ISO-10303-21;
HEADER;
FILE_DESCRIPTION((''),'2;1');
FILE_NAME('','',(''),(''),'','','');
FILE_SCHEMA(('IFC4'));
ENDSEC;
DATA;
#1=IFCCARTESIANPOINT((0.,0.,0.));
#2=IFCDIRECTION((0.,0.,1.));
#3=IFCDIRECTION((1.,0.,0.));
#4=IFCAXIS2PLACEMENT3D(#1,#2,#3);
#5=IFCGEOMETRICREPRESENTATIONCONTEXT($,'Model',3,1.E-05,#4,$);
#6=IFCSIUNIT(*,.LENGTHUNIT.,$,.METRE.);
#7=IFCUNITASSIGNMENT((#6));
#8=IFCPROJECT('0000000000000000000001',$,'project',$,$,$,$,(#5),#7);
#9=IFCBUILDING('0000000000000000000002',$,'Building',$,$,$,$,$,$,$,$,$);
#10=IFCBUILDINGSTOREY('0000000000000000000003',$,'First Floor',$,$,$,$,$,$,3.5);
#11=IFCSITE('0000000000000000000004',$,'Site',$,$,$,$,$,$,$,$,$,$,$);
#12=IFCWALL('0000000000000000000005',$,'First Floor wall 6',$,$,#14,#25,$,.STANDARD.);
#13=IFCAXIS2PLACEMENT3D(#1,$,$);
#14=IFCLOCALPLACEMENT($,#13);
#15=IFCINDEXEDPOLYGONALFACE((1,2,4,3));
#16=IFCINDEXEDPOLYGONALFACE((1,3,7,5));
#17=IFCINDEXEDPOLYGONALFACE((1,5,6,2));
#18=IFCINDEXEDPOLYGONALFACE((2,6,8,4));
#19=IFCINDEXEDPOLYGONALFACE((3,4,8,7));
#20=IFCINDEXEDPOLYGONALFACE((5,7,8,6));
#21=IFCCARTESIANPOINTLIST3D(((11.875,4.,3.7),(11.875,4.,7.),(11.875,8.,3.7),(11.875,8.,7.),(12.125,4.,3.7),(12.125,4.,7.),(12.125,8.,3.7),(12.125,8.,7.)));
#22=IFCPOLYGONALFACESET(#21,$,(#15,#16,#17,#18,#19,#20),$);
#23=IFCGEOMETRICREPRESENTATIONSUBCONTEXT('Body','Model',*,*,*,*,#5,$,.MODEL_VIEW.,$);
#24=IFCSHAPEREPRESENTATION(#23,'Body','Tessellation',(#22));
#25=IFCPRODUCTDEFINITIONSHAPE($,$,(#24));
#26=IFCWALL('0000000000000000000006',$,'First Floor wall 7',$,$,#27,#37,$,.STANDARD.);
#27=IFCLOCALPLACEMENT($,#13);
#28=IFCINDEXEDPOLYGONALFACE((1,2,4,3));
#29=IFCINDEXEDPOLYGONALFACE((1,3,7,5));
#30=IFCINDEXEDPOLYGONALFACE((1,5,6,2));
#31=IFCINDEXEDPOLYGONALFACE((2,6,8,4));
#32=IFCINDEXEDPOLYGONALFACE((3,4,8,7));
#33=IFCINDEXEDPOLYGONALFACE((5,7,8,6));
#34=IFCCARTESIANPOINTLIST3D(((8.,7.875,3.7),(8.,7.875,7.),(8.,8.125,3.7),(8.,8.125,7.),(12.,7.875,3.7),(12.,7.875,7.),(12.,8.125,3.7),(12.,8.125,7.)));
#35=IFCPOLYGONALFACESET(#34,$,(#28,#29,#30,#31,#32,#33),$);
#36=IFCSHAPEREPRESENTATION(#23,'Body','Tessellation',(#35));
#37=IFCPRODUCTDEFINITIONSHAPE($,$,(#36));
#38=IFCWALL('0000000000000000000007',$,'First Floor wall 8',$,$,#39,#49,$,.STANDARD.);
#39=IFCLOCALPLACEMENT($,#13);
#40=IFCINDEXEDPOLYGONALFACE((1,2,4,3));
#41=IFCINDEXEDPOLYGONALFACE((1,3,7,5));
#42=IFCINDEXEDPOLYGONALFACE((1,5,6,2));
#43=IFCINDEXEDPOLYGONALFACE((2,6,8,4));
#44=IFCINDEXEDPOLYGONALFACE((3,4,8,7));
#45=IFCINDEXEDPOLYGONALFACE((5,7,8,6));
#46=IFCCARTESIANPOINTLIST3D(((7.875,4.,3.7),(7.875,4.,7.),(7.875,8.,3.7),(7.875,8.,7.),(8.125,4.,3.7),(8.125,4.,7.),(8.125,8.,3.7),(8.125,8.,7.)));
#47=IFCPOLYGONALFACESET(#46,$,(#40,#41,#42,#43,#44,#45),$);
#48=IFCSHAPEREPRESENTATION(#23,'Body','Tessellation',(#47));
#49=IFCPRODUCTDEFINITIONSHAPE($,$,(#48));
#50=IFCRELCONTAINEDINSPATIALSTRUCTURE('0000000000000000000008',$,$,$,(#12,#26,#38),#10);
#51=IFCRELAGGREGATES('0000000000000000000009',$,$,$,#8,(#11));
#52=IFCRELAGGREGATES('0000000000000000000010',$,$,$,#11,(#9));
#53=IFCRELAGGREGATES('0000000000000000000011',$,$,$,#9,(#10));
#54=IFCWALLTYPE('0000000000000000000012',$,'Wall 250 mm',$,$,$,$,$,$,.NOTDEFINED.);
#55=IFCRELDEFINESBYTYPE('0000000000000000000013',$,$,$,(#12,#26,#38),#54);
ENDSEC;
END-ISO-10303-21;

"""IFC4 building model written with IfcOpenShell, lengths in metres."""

from ifc_helpers import new_model, si_unit, frame, origin_with_axes, place, context, subcontext, project, spatial, indexed_curve, outline, extrude, type_object, element, save


model = new_model("IFC4")

# Units and contexts
model_context = context("Model", 3, precision=1e-05, world=origin_with_axes())
body_context = subcontext(model_context, "Body", "Model", "MODEL_VIEW")
ifc_project = project(units=[si_unit("LENGTHUNIT", "METRE")], contexts=[model_context])

# Site, building, storey
site = spatial("IfcSite", under=ifc_project, Name="Site")
building = spatial("IfcBuilding", under=site, Name="Building")
storey = spatial("IfcBuildingStorey", under=building, Name="First Floor", Elevation=3.5)

# Walls
wall_type_1 = type_object("IfcWallType", Name="Wall 250 mm", PredefinedType="NOTDEFINED")
for number, where, z_axis, x_axis, name in (
    (1, (12.0, 4.0, 3.7), (0.0, 0.0, 1.0), (0.0, 1.0, 0.0), "First Floor wall 6"),
    (2, (12.0, 8.0, 3.7), (0.0, 0.0, 1.0), (-1.0, 0.0, 0.0), "First Floor wall 7"),
    (3, (8.0, 8.0, 3.7), (0.0, 0.0, 1.0), (0.0, -1.0, 0.0), "First Floor wall 8"),
):
    element("IfcWall", number, at=place(None, frame(where, z_axis=z_axis, x_axis=x_axis)), inside=storey, type_object=wall_type_1, Name=name, PredefinedType="STANDARD", context=body_context, shape_type="SweptSolid", body=[
        extrude(outline(indexed_curve([(0.0, 0.0), (0.0, 0.25), (4.0, 0.25), (4.0, 0.0), (0.0, 0.0)], self_intersect=False)), frame((0.0, -0.125, 0.0), z_axis=(0.0, 0.0, 1.0), x_axis=(1.0, 0.0, 0.0)), (0.0, 0.0, 1.0), 3.3),
    ])

save(model, "model.ifc")
